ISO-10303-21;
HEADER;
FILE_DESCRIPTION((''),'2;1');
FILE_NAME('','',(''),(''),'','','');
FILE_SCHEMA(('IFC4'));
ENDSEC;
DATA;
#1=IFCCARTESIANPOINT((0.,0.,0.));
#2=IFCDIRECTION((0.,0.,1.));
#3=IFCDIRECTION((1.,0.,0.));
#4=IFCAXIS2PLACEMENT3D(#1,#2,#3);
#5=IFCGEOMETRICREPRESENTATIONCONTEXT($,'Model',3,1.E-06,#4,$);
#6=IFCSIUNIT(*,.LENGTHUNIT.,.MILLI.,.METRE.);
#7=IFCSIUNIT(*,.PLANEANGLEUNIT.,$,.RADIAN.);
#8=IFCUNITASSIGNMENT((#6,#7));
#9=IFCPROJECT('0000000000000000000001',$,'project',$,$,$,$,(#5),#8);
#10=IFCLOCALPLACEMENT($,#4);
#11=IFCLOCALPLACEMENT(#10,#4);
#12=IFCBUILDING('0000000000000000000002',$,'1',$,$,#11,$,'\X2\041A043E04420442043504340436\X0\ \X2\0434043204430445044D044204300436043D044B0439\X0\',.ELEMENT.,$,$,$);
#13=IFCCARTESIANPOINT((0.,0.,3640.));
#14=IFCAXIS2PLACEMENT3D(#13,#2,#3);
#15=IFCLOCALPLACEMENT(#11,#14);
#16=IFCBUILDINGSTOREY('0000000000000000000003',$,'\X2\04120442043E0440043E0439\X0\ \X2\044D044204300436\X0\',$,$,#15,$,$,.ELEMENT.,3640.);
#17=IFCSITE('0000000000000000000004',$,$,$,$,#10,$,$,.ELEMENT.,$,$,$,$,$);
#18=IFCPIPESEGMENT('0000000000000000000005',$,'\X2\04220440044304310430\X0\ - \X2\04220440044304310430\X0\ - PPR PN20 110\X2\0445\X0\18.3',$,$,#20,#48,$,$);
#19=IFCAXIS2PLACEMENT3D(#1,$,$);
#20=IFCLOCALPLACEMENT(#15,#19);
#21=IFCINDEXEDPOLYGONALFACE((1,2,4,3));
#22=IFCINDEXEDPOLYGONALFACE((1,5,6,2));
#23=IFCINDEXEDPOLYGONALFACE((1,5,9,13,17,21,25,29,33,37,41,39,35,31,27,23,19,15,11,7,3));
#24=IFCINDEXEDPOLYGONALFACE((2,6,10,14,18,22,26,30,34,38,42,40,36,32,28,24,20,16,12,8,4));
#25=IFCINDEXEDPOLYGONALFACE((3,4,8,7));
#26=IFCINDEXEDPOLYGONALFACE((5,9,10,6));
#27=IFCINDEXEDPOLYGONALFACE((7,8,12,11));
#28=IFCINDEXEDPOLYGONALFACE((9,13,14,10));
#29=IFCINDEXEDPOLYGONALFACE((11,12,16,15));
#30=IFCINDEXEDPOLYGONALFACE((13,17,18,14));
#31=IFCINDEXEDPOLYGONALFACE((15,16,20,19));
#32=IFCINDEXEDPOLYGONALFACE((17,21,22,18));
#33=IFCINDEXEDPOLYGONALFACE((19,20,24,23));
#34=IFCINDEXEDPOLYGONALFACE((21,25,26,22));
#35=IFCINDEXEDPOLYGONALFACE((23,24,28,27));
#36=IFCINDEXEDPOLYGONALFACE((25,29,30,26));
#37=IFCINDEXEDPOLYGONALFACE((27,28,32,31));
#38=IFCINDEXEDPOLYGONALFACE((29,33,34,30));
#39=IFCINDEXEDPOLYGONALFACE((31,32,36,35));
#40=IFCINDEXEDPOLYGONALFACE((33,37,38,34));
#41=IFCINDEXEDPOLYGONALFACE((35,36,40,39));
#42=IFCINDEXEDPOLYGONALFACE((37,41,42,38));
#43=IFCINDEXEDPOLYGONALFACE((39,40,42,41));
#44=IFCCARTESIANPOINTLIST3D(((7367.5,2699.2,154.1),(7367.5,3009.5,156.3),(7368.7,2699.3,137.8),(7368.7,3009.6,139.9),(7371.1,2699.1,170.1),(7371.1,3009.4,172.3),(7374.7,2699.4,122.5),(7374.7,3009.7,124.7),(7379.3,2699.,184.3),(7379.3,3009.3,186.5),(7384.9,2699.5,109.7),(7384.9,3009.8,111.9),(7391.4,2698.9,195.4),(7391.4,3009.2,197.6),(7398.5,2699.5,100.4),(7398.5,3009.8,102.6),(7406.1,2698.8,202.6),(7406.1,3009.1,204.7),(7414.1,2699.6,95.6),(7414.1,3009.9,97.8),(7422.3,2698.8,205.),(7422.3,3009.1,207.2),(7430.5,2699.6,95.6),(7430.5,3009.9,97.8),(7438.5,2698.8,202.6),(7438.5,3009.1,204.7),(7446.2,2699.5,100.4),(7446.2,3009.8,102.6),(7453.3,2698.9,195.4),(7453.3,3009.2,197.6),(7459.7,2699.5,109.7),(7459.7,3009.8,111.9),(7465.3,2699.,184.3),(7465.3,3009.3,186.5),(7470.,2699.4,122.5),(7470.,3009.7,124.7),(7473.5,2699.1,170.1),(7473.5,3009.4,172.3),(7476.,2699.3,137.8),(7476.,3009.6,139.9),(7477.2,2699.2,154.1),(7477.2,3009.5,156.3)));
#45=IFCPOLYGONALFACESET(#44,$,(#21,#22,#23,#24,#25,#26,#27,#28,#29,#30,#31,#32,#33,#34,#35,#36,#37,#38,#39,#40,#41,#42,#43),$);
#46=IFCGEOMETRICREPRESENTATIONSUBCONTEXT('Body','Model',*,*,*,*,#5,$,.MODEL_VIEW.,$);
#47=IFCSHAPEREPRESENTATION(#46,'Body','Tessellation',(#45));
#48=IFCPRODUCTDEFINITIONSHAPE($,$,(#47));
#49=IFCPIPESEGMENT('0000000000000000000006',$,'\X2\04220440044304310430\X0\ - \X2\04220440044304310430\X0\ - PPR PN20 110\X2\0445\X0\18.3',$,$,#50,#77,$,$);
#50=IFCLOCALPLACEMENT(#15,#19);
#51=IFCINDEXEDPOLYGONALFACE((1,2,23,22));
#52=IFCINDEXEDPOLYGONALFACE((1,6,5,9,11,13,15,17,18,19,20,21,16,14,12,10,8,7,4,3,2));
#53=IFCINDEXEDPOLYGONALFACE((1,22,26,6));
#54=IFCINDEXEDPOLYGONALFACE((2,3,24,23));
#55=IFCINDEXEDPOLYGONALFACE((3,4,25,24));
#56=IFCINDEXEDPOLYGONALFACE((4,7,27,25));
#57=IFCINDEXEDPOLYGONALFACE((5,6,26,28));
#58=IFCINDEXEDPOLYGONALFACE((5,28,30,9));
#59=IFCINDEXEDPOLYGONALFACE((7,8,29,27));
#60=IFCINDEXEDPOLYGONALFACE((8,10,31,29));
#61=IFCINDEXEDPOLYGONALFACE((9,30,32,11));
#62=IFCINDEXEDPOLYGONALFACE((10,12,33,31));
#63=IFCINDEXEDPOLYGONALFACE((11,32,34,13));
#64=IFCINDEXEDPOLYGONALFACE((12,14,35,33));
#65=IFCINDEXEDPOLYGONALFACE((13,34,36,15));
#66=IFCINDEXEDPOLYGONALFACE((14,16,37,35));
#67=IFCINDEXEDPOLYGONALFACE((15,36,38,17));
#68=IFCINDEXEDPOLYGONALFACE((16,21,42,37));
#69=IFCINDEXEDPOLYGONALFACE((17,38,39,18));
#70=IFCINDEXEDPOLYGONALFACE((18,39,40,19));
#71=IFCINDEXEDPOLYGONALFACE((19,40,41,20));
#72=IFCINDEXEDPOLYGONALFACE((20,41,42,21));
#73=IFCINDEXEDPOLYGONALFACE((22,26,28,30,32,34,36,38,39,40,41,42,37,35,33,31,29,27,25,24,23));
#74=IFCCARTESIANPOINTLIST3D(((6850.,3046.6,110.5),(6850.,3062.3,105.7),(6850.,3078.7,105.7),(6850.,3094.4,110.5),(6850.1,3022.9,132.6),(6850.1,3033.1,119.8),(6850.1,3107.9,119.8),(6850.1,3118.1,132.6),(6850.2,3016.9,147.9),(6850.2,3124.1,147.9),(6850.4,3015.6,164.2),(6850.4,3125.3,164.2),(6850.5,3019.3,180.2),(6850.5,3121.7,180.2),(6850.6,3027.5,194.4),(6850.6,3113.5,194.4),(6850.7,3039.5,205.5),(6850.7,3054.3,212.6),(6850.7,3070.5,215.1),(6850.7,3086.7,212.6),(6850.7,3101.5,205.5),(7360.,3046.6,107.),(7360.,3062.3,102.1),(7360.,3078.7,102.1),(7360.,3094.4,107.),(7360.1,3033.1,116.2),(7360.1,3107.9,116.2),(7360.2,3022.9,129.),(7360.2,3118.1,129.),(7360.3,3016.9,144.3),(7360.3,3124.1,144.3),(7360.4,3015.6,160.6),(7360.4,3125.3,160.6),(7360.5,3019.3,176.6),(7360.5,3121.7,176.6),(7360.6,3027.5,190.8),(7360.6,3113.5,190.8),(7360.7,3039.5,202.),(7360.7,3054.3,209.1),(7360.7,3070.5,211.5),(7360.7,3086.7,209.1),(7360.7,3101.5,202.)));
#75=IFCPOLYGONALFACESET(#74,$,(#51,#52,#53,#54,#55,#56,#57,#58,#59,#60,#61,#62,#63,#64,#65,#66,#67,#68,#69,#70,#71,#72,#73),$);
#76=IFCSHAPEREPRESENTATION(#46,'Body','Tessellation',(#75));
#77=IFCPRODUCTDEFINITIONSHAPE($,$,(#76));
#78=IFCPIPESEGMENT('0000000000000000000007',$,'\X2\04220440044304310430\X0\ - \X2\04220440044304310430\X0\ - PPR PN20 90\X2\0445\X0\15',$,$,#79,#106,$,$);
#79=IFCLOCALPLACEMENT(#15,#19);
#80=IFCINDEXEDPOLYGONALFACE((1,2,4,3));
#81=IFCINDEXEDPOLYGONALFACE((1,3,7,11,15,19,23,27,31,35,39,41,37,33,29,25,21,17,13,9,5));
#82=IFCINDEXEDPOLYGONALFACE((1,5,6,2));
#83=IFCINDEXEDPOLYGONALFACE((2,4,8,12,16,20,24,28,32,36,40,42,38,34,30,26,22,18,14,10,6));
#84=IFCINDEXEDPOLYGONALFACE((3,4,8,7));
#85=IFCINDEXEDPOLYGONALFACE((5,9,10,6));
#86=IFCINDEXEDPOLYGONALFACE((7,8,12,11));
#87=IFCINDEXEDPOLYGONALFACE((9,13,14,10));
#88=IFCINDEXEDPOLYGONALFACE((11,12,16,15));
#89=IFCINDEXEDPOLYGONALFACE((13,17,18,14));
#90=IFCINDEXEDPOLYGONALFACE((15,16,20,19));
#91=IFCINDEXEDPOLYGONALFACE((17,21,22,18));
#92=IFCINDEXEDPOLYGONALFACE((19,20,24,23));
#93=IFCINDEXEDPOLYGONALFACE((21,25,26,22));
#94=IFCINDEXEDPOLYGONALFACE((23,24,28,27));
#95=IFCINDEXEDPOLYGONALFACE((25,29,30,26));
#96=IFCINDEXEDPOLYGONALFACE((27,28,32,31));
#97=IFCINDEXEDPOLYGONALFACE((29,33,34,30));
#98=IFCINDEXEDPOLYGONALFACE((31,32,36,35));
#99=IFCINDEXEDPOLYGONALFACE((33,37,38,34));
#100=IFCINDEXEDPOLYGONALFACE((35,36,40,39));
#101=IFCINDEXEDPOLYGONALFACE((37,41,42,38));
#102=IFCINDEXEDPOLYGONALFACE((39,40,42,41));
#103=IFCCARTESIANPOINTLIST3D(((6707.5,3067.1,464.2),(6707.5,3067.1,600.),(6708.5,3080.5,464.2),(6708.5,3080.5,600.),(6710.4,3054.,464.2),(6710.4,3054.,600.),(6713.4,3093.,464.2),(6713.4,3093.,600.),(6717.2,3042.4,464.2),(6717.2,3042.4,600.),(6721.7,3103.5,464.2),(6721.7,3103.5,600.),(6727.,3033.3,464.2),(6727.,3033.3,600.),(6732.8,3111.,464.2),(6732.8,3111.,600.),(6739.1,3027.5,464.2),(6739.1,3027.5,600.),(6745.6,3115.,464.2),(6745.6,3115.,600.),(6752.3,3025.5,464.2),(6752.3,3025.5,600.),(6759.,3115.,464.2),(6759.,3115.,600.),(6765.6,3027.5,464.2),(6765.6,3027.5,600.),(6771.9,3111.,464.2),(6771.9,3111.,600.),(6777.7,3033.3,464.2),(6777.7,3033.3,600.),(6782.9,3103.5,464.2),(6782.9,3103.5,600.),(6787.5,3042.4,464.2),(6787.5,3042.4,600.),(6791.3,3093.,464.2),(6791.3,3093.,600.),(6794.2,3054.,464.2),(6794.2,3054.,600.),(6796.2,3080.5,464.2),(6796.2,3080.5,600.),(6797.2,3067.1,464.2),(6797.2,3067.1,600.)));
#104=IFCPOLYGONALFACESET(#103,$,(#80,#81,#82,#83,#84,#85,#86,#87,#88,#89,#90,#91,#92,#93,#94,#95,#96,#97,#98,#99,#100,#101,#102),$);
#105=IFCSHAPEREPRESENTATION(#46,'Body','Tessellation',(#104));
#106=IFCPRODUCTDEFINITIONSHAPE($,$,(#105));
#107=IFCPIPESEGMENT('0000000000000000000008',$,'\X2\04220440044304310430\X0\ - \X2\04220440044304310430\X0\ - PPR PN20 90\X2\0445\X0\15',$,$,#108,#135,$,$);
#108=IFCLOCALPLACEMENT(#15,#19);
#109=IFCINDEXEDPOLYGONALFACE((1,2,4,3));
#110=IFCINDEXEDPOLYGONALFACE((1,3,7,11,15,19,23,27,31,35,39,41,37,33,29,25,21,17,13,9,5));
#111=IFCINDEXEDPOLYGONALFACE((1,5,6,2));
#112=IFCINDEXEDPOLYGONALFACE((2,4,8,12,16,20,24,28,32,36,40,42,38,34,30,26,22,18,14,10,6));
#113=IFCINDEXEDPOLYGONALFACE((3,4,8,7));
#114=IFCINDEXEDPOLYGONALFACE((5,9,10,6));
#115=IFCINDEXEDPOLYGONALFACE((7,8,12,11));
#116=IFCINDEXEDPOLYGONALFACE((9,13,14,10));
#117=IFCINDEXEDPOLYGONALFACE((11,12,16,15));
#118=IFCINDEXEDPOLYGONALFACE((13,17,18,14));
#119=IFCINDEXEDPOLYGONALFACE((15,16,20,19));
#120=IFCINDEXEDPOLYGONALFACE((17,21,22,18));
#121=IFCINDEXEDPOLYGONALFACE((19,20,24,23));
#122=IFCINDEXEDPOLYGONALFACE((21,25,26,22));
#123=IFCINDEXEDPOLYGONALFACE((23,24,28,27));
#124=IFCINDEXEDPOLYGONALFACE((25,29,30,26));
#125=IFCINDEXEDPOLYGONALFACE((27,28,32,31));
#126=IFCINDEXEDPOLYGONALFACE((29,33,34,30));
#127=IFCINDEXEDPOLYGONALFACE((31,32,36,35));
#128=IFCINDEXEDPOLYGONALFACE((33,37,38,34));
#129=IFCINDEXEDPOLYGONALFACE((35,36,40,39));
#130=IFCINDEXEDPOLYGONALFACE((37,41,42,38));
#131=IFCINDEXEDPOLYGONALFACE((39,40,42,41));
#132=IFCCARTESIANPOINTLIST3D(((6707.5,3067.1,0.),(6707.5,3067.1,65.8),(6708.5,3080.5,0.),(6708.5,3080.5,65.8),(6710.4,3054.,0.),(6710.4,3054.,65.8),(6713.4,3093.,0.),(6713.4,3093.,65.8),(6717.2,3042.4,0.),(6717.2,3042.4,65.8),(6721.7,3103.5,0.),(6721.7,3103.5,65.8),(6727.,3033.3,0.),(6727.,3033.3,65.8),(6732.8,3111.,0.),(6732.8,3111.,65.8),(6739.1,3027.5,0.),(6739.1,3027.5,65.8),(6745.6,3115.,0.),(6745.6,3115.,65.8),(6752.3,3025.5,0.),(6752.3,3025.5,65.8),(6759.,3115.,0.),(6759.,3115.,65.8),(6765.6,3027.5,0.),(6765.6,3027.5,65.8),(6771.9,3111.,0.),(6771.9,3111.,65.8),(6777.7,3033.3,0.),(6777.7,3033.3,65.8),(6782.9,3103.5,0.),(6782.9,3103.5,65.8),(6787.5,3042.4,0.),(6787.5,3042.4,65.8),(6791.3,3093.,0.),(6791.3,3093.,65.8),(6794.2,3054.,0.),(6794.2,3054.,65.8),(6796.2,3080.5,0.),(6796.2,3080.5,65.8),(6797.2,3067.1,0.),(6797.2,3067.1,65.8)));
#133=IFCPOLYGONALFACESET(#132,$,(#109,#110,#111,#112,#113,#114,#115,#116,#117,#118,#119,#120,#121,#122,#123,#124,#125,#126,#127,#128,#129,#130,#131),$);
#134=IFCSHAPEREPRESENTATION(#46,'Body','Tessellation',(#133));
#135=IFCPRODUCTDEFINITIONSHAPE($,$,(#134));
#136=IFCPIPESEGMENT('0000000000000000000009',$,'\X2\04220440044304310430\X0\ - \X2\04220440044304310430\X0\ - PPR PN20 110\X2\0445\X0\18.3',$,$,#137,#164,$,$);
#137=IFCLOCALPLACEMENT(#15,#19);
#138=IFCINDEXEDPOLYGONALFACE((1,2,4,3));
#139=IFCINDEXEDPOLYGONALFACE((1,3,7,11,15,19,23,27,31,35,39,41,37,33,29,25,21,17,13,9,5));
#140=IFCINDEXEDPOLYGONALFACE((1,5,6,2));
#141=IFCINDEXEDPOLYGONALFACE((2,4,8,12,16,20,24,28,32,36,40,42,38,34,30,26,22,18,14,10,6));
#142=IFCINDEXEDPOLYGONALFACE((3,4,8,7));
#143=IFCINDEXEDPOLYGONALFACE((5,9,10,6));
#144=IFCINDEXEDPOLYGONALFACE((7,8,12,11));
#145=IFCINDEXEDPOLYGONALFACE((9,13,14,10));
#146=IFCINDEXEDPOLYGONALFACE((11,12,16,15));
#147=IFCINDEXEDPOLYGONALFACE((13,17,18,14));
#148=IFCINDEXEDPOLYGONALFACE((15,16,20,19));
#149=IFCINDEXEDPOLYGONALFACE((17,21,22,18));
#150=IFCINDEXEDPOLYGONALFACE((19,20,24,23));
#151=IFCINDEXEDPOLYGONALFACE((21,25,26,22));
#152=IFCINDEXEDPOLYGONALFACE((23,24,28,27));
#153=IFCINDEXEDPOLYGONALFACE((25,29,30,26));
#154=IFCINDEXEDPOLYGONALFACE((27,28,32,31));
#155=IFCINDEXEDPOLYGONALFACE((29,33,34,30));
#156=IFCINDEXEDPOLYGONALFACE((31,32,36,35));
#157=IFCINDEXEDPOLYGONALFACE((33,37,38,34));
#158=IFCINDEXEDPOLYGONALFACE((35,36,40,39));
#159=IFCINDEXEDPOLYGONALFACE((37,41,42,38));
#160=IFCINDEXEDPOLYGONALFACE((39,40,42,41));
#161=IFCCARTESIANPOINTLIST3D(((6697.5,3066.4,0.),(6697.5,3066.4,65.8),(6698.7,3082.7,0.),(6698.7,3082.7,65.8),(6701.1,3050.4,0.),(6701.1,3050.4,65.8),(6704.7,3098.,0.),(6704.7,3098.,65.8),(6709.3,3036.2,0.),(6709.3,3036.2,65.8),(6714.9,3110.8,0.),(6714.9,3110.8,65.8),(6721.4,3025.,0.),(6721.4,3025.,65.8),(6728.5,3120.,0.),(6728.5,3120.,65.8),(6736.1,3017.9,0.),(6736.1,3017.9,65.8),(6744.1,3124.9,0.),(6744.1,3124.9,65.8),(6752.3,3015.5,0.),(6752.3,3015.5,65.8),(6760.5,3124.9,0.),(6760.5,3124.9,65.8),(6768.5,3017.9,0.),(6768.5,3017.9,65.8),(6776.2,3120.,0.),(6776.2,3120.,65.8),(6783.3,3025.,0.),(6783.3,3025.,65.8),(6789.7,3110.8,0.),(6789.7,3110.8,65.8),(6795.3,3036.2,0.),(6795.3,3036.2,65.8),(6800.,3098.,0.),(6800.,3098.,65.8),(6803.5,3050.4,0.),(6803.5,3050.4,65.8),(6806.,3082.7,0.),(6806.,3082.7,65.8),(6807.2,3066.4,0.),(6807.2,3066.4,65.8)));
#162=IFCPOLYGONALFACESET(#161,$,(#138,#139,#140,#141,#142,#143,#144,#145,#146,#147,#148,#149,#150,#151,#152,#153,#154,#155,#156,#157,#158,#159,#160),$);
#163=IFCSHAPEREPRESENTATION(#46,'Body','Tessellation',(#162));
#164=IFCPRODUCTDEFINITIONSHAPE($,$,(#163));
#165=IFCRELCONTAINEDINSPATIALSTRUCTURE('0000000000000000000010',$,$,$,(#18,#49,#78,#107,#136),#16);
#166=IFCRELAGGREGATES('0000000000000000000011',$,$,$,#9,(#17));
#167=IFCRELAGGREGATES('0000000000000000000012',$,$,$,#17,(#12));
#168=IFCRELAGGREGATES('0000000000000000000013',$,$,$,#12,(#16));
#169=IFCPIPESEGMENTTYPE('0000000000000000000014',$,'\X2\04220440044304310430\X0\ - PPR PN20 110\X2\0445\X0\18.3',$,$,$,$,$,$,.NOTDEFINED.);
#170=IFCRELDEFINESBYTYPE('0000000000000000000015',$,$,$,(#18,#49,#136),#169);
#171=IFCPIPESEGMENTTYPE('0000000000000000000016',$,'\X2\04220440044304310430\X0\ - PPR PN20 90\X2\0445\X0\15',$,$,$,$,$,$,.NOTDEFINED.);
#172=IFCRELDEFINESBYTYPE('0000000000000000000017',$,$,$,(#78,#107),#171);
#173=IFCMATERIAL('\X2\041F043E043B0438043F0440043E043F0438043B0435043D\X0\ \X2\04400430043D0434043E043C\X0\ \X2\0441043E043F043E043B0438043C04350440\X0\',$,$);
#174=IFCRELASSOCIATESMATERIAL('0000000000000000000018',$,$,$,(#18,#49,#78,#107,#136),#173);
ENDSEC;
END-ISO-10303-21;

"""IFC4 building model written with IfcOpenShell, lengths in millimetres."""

from ifc_helpers import new_model, entity, si_unit, frame, origin_with_axes, place, context, subcontext, project, spatial, source, transform, mapped, material, type_object, element, save


model = new_model("IFC4")

# Units and contexts
model_context = context("Model", 3, precision=1e-06, world=origin_with_axes())
body_context = subcontext(model_context, "Body", "Model", "MODEL_VIEW")
ifc_project = project(units=[si_unit("LENGTHUNIT", "METRE", prefix="MILLI"), si_unit("PLANEANGLEUNIT", "RADIAN")], contexts=[model_context])

# Site, building, storey
site_placement = place(None, origin_with_axes())
site = spatial("IfcSite", under=ifc_project, at=site_placement, CompositionType="ELEMENT")
building_placement = place(site_placement, origin_with_axes())
building = spatial("IfcBuilding", under=site, at=building_placement, Name="1", LongName="Коттедж двухэтажный", CompositionType="ELEMENT")
storey_placement = place(building_placement, frame((0.0, 0.0, 3640.0), z_axis=(0.0, 0.0, 1.0), x_axis=(1.0, 0.0, 0.0)))
storey = spatial("IfcBuildingStorey", under=building, at=storey_placement, Name="Второй этаж", CompositionType="ELEMENT", Elevation=3640.0)

# Pipe segments
ifc_material = material(Name="Полипропилен рандом сополимер")
pipe_segment_type_1 = type_object("IfcPipeSegmentType", Name="Труба - PPR PN20 110х18.3", PredefinedType="NOTDEFINED")
shared_shape_1 = source(origin_with_axes(), body_context, "Body", "AdvancedSweptSolid", [
    entity("IfcSweptDiskSolid", entity("IfcIndexedPolyCurve", entity("IfcCartesianPointList3D", [[0.0, 0.0, 0.0], [310.3, 0.0, 2.2]]), [entity("IfcLineIndex", [1, 2])]), 55.0),
])
pipe_segment_1_placement = place(storey_placement, frame((7422.3, 2699.2, 150.0), z_axis=(0.0, 0.0, 1.0), x_axis=(0.0, 1.0, 0.0)))
element("IfcPipeSegment", 1, at=pipe_segment_1_placement, inside=storey, type_object=pipe_segment_type_1, material=ifc_material, Name="Труба - Труба - PPR PN20 110х18.3", context=body_context, shape_type="MappedRepresentation", body=[
    mapped(shared_shape_1, transform((0.0, 0.0, 0.0), x_axis=(1.0, 0.0, 0.0), y_axis=(0.0, 1.0, 0.0), z_axis=(0.0, 0.0, 1.0), scale=1.0)),
])
shared_shape_2 = source(origin_with_axes(), body_context, "Body", "AdvancedSweptSolid", [
    entity("IfcSweptDiskSolid", entity("IfcIndexedPolyCurve", entity("IfcCartesianPointList3D", [[0.0, 0.0, 0.0], [510.0, 0.0, 3.6]]), [entity("IfcLineIndex", [1, 2])]), 55.0),
])
pipe_segment_2_placement = place(storey_placement, frame((7360.4, 3070.5, 156.5), z_axis=(0.0, 0.0, 1.0), x_axis=(-1.0, 0.0, 0.0)))
element("IfcPipeSegment", 2, at=pipe_segment_2_placement, inside=storey, type_object=pipe_segment_type_1, material=ifc_material, Name="Труба - Труба - PPR PN20 110х18.3", context=body_context, shape_type="MappedRepresentation", body=[
    mapped(shared_shape_2, transform((0.0, 0.0, 0.0), x_axis=(1.0, 0.0, 0.0), y_axis=(0.0, 1.0, 0.0), z_axis=(0.0, 0.0, 1.0), scale=1.0)),
])
pipe_segment_type_2 = type_object("IfcPipeSegmentType", Name="Труба - PPR PN20 90х15", PredefinedType="NOTDEFINED")
shared_shape_3 = source(origin_with_axes(), body_context, "Body", "AdvancedSweptSolid", [
    entity("IfcSweptDiskSolid", entity("IfcIndexedPolyCurve", entity("IfcCartesianPointList3D", [[0.0, 0.0, 0.0], [0.0, 0.0, -135.8]]), [entity("IfcLineIndex", [1, 2])]), 45.0),
])
pipe_segment_3_placement = place(storey_placement, frame((6752.3, 3070.5, 600.0), z_axis=(0.0, 0.0, 1.0), x_axis=(0.0, 1.0, 0.0)))
element("IfcPipeSegment", 3, at=pipe_segment_3_placement, inside=storey, type_object=pipe_segment_type_2, material=ifc_material, Name="Труба - Труба - PPR PN20 90х15", context=body_context, shape_type="MappedRepresentation", body=[
    mapped(shared_shape_3, transform((0.0, 0.0, 0.0), x_axis=(1.0, 0.0, 0.0), y_axis=(0.0, 1.0, 0.0), z_axis=(0.0, 0.0, 1.0), scale=1.0)),
])
shared_shape_4 = source(origin_with_axes(), body_context, "Body", "AdvancedSweptSolid", [
    entity("IfcSweptDiskSolid", entity("IfcIndexedPolyCurve", entity("IfcCartesianPointList3D", [[0.0, 0.0, 0.0], [0.0, 0.0, -65.8]]), [entity("IfcLineIndex", [1, 2])]), 45.0),
])
pipe_segment_4_placement = place(storey_placement, frame((6752.3, 3070.5, 65.8), z_axis=(0.0, 0.0, 1.0), x_axis=(0.0, 1.0, 0.0)))
element("IfcPipeSegment", 4, at=pipe_segment_4_placement, inside=storey, type_object=pipe_segment_type_2, material=ifc_material, Name="Труба - Труба - PPR PN20 90х15", context=body_context, shape_type="MappedRepresentation", body=[
    mapped(shared_shape_4, transform((0.0, 0.0, 0.0), x_axis=(1.0, 0.0, 0.0), y_axis=(0.0, 1.0, 0.0), z_axis=(0.0, 0.0, 1.0), scale=1.0)),
])
shared_shape_5 = source(origin_with_axes(), body_context, "Body", "AdvancedSweptSolid", [
    entity("IfcSweptDiskSolid", entity("IfcIndexedPolyCurve", entity("IfcCartesianPointList3D", [[0.0, 0.0, 0.0], [0.0, 0.0, -65.8]]), [entity("IfcLineIndex", [1, 2])]), 55.0),
])
pipe_segment_5_placement = place(storey_placement, frame((6752.3, 3070.5, 65.8), z_axis=(0.0, 0.0, 1.0), x_axis=(0.0, 1.0, 0.0)))
element("IfcPipeSegment", 5, at=pipe_segment_5_placement, inside=storey, type_object=pipe_segment_type_1, material=ifc_material, Name="Труба - Труба - PPR PN20 110х18.3", context=body_context, shape_type="MappedRepresentation", body=[
    mapped(shared_shape_5, transform((0.0, 0.0, 0.0), x_axis=(1.0, 0.0, 0.0), y_axis=(0.0, 1.0, 0.0), z_axis=(0.0, 0.0, 1.0), scale=1.0)),
])

save(model, "model.ifc")
